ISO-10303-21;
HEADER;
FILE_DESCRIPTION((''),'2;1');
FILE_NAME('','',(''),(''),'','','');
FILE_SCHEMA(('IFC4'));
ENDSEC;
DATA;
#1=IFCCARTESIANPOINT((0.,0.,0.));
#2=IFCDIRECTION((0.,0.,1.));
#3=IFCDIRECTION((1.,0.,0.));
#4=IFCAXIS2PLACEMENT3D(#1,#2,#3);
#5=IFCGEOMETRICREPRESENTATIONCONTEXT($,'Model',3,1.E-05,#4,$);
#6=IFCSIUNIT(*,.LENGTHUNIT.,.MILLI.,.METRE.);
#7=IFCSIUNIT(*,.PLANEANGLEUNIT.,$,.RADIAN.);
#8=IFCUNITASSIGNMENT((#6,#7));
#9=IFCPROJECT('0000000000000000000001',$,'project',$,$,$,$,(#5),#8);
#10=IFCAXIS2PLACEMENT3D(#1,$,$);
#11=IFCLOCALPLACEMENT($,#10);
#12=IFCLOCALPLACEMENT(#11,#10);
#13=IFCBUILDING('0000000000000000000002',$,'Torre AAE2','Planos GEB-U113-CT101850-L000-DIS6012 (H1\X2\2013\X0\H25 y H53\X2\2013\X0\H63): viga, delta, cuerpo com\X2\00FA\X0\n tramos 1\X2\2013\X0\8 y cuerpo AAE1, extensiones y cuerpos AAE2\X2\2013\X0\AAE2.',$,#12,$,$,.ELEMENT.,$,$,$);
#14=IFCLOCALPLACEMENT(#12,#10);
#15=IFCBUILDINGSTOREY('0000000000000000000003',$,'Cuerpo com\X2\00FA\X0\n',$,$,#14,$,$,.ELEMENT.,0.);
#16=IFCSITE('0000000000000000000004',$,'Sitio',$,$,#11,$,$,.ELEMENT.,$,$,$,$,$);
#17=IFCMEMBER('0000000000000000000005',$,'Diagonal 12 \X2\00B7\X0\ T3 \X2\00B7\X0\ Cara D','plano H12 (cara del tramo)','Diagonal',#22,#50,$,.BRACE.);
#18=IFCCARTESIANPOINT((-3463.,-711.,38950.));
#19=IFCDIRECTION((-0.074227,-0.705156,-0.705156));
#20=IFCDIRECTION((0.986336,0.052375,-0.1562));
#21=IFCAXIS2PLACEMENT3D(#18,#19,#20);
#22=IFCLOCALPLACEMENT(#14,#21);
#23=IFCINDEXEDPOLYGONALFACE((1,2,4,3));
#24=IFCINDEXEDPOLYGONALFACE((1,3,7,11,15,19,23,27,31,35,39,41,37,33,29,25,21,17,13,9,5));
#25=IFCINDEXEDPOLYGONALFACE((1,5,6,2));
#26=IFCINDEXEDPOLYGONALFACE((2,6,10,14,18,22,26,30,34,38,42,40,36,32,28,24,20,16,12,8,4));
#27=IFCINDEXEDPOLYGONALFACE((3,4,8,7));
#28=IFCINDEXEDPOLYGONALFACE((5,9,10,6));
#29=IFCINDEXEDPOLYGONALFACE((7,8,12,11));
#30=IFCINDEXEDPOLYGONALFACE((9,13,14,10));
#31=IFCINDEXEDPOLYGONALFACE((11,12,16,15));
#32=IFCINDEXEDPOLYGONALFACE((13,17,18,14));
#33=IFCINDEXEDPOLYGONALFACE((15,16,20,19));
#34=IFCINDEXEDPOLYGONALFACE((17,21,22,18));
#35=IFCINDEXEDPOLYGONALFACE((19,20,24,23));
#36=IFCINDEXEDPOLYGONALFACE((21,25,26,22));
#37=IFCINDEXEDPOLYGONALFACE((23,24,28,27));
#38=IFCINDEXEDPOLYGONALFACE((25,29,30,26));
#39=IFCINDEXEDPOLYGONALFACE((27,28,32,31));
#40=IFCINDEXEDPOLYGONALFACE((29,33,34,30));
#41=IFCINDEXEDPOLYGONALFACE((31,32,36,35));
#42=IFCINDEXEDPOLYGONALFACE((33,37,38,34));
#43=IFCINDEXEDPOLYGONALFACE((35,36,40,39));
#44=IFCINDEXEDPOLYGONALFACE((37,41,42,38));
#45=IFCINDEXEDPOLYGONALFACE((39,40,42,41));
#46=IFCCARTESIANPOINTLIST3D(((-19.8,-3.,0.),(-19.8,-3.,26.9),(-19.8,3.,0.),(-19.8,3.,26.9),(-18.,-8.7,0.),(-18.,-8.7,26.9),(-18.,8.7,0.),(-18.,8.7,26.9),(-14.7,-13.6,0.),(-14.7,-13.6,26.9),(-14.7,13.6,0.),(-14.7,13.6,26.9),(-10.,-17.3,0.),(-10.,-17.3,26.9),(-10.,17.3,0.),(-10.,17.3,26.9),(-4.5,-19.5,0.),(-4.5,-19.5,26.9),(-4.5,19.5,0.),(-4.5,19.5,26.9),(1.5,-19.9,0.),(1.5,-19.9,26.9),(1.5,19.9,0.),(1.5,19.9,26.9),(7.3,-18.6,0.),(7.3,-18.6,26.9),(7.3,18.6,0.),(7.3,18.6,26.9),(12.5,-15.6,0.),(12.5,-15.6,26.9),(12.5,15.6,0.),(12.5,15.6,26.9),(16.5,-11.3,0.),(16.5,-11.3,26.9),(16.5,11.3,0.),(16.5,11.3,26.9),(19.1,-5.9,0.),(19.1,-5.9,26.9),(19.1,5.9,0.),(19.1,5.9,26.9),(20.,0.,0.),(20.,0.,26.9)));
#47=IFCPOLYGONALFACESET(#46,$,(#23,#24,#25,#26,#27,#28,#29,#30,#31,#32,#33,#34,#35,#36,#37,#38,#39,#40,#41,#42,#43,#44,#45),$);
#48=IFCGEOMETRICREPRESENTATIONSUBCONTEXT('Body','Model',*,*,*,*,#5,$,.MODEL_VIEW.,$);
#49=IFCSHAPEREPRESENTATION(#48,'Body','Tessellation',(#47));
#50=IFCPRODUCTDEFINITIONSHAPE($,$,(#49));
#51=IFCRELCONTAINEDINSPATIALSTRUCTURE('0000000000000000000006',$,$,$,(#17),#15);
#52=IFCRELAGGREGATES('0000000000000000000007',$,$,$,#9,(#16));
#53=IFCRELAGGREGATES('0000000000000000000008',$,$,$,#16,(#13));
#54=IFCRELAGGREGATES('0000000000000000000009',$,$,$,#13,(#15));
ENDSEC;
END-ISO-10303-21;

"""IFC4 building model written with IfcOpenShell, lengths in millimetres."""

from ifc_helpers import new_model, si_unit, frame, origin, origin_with_axes, place, context, subcontext, project, spatial, circle, extrude, element, save


model = new_model("IFC4")

# Units and contexts
model_context = context("Model", 3, precision=1e-05, world=origin_with_axes())
body_context = subcontext(model_context, "Body", "Model", "MODEL_VIEW")
ifc_project = project(units=[si_unit("LENGTHUNIT", "METRE", prefix="MILLI"), si_unit("PLANEANGLEUNIT", "RADIAN")], contexts=[model_context])

# Site, building, storey
site_placement = place(None, origin())
site = spatial("IfcSite", under=ifc_project, at=site_placement, Name="Sitio", CompositionType="ELEMENT")
building_placement = place(site_placement, origin())
building = spatial("IfcBuilding", under=site, at=building_placement, Name="Torre AAE2", Description="Planos GEB-U113-CT101850-L000-DIS6012 (H1–H25 y H53–H63): viga, delta, cuerpo común tramos 1–8 y cuerpo AAE1, extensiones y cuerpos AAE2–AAE2.", CompositionType="ELEMENT")
storey_placement = place(building_placement, origin())
storey = spatial("IfcBuildingStorey", under=building, at=storey_placement, Name="Cuerpo común", CompositionType="ELEMENT", Elevation=0.0)

# Member
member_1_placement = place(storey_placement, frame((-3463.0, -711.0, 38950.0), z_axis=(-0.074227, -0.705156, -0.705156), x_axis=(0.986336, 0.052375, -0.1562)))
element("IfcMember", 1, at=member_1_placement, inside=storey, Name="Diagonal 12 · T3 · Cara D", Description="plano H12 (cara del tramo)", ObjectType="Diagonal", PredefinedType="BRACE", context=body_context, shape_type="SweptSolid", body=[
    extrude(circle(Radius=20.0), None, (0.0, 0.0, 1.0), 26.9),
])

save(model, "model.ifc")
